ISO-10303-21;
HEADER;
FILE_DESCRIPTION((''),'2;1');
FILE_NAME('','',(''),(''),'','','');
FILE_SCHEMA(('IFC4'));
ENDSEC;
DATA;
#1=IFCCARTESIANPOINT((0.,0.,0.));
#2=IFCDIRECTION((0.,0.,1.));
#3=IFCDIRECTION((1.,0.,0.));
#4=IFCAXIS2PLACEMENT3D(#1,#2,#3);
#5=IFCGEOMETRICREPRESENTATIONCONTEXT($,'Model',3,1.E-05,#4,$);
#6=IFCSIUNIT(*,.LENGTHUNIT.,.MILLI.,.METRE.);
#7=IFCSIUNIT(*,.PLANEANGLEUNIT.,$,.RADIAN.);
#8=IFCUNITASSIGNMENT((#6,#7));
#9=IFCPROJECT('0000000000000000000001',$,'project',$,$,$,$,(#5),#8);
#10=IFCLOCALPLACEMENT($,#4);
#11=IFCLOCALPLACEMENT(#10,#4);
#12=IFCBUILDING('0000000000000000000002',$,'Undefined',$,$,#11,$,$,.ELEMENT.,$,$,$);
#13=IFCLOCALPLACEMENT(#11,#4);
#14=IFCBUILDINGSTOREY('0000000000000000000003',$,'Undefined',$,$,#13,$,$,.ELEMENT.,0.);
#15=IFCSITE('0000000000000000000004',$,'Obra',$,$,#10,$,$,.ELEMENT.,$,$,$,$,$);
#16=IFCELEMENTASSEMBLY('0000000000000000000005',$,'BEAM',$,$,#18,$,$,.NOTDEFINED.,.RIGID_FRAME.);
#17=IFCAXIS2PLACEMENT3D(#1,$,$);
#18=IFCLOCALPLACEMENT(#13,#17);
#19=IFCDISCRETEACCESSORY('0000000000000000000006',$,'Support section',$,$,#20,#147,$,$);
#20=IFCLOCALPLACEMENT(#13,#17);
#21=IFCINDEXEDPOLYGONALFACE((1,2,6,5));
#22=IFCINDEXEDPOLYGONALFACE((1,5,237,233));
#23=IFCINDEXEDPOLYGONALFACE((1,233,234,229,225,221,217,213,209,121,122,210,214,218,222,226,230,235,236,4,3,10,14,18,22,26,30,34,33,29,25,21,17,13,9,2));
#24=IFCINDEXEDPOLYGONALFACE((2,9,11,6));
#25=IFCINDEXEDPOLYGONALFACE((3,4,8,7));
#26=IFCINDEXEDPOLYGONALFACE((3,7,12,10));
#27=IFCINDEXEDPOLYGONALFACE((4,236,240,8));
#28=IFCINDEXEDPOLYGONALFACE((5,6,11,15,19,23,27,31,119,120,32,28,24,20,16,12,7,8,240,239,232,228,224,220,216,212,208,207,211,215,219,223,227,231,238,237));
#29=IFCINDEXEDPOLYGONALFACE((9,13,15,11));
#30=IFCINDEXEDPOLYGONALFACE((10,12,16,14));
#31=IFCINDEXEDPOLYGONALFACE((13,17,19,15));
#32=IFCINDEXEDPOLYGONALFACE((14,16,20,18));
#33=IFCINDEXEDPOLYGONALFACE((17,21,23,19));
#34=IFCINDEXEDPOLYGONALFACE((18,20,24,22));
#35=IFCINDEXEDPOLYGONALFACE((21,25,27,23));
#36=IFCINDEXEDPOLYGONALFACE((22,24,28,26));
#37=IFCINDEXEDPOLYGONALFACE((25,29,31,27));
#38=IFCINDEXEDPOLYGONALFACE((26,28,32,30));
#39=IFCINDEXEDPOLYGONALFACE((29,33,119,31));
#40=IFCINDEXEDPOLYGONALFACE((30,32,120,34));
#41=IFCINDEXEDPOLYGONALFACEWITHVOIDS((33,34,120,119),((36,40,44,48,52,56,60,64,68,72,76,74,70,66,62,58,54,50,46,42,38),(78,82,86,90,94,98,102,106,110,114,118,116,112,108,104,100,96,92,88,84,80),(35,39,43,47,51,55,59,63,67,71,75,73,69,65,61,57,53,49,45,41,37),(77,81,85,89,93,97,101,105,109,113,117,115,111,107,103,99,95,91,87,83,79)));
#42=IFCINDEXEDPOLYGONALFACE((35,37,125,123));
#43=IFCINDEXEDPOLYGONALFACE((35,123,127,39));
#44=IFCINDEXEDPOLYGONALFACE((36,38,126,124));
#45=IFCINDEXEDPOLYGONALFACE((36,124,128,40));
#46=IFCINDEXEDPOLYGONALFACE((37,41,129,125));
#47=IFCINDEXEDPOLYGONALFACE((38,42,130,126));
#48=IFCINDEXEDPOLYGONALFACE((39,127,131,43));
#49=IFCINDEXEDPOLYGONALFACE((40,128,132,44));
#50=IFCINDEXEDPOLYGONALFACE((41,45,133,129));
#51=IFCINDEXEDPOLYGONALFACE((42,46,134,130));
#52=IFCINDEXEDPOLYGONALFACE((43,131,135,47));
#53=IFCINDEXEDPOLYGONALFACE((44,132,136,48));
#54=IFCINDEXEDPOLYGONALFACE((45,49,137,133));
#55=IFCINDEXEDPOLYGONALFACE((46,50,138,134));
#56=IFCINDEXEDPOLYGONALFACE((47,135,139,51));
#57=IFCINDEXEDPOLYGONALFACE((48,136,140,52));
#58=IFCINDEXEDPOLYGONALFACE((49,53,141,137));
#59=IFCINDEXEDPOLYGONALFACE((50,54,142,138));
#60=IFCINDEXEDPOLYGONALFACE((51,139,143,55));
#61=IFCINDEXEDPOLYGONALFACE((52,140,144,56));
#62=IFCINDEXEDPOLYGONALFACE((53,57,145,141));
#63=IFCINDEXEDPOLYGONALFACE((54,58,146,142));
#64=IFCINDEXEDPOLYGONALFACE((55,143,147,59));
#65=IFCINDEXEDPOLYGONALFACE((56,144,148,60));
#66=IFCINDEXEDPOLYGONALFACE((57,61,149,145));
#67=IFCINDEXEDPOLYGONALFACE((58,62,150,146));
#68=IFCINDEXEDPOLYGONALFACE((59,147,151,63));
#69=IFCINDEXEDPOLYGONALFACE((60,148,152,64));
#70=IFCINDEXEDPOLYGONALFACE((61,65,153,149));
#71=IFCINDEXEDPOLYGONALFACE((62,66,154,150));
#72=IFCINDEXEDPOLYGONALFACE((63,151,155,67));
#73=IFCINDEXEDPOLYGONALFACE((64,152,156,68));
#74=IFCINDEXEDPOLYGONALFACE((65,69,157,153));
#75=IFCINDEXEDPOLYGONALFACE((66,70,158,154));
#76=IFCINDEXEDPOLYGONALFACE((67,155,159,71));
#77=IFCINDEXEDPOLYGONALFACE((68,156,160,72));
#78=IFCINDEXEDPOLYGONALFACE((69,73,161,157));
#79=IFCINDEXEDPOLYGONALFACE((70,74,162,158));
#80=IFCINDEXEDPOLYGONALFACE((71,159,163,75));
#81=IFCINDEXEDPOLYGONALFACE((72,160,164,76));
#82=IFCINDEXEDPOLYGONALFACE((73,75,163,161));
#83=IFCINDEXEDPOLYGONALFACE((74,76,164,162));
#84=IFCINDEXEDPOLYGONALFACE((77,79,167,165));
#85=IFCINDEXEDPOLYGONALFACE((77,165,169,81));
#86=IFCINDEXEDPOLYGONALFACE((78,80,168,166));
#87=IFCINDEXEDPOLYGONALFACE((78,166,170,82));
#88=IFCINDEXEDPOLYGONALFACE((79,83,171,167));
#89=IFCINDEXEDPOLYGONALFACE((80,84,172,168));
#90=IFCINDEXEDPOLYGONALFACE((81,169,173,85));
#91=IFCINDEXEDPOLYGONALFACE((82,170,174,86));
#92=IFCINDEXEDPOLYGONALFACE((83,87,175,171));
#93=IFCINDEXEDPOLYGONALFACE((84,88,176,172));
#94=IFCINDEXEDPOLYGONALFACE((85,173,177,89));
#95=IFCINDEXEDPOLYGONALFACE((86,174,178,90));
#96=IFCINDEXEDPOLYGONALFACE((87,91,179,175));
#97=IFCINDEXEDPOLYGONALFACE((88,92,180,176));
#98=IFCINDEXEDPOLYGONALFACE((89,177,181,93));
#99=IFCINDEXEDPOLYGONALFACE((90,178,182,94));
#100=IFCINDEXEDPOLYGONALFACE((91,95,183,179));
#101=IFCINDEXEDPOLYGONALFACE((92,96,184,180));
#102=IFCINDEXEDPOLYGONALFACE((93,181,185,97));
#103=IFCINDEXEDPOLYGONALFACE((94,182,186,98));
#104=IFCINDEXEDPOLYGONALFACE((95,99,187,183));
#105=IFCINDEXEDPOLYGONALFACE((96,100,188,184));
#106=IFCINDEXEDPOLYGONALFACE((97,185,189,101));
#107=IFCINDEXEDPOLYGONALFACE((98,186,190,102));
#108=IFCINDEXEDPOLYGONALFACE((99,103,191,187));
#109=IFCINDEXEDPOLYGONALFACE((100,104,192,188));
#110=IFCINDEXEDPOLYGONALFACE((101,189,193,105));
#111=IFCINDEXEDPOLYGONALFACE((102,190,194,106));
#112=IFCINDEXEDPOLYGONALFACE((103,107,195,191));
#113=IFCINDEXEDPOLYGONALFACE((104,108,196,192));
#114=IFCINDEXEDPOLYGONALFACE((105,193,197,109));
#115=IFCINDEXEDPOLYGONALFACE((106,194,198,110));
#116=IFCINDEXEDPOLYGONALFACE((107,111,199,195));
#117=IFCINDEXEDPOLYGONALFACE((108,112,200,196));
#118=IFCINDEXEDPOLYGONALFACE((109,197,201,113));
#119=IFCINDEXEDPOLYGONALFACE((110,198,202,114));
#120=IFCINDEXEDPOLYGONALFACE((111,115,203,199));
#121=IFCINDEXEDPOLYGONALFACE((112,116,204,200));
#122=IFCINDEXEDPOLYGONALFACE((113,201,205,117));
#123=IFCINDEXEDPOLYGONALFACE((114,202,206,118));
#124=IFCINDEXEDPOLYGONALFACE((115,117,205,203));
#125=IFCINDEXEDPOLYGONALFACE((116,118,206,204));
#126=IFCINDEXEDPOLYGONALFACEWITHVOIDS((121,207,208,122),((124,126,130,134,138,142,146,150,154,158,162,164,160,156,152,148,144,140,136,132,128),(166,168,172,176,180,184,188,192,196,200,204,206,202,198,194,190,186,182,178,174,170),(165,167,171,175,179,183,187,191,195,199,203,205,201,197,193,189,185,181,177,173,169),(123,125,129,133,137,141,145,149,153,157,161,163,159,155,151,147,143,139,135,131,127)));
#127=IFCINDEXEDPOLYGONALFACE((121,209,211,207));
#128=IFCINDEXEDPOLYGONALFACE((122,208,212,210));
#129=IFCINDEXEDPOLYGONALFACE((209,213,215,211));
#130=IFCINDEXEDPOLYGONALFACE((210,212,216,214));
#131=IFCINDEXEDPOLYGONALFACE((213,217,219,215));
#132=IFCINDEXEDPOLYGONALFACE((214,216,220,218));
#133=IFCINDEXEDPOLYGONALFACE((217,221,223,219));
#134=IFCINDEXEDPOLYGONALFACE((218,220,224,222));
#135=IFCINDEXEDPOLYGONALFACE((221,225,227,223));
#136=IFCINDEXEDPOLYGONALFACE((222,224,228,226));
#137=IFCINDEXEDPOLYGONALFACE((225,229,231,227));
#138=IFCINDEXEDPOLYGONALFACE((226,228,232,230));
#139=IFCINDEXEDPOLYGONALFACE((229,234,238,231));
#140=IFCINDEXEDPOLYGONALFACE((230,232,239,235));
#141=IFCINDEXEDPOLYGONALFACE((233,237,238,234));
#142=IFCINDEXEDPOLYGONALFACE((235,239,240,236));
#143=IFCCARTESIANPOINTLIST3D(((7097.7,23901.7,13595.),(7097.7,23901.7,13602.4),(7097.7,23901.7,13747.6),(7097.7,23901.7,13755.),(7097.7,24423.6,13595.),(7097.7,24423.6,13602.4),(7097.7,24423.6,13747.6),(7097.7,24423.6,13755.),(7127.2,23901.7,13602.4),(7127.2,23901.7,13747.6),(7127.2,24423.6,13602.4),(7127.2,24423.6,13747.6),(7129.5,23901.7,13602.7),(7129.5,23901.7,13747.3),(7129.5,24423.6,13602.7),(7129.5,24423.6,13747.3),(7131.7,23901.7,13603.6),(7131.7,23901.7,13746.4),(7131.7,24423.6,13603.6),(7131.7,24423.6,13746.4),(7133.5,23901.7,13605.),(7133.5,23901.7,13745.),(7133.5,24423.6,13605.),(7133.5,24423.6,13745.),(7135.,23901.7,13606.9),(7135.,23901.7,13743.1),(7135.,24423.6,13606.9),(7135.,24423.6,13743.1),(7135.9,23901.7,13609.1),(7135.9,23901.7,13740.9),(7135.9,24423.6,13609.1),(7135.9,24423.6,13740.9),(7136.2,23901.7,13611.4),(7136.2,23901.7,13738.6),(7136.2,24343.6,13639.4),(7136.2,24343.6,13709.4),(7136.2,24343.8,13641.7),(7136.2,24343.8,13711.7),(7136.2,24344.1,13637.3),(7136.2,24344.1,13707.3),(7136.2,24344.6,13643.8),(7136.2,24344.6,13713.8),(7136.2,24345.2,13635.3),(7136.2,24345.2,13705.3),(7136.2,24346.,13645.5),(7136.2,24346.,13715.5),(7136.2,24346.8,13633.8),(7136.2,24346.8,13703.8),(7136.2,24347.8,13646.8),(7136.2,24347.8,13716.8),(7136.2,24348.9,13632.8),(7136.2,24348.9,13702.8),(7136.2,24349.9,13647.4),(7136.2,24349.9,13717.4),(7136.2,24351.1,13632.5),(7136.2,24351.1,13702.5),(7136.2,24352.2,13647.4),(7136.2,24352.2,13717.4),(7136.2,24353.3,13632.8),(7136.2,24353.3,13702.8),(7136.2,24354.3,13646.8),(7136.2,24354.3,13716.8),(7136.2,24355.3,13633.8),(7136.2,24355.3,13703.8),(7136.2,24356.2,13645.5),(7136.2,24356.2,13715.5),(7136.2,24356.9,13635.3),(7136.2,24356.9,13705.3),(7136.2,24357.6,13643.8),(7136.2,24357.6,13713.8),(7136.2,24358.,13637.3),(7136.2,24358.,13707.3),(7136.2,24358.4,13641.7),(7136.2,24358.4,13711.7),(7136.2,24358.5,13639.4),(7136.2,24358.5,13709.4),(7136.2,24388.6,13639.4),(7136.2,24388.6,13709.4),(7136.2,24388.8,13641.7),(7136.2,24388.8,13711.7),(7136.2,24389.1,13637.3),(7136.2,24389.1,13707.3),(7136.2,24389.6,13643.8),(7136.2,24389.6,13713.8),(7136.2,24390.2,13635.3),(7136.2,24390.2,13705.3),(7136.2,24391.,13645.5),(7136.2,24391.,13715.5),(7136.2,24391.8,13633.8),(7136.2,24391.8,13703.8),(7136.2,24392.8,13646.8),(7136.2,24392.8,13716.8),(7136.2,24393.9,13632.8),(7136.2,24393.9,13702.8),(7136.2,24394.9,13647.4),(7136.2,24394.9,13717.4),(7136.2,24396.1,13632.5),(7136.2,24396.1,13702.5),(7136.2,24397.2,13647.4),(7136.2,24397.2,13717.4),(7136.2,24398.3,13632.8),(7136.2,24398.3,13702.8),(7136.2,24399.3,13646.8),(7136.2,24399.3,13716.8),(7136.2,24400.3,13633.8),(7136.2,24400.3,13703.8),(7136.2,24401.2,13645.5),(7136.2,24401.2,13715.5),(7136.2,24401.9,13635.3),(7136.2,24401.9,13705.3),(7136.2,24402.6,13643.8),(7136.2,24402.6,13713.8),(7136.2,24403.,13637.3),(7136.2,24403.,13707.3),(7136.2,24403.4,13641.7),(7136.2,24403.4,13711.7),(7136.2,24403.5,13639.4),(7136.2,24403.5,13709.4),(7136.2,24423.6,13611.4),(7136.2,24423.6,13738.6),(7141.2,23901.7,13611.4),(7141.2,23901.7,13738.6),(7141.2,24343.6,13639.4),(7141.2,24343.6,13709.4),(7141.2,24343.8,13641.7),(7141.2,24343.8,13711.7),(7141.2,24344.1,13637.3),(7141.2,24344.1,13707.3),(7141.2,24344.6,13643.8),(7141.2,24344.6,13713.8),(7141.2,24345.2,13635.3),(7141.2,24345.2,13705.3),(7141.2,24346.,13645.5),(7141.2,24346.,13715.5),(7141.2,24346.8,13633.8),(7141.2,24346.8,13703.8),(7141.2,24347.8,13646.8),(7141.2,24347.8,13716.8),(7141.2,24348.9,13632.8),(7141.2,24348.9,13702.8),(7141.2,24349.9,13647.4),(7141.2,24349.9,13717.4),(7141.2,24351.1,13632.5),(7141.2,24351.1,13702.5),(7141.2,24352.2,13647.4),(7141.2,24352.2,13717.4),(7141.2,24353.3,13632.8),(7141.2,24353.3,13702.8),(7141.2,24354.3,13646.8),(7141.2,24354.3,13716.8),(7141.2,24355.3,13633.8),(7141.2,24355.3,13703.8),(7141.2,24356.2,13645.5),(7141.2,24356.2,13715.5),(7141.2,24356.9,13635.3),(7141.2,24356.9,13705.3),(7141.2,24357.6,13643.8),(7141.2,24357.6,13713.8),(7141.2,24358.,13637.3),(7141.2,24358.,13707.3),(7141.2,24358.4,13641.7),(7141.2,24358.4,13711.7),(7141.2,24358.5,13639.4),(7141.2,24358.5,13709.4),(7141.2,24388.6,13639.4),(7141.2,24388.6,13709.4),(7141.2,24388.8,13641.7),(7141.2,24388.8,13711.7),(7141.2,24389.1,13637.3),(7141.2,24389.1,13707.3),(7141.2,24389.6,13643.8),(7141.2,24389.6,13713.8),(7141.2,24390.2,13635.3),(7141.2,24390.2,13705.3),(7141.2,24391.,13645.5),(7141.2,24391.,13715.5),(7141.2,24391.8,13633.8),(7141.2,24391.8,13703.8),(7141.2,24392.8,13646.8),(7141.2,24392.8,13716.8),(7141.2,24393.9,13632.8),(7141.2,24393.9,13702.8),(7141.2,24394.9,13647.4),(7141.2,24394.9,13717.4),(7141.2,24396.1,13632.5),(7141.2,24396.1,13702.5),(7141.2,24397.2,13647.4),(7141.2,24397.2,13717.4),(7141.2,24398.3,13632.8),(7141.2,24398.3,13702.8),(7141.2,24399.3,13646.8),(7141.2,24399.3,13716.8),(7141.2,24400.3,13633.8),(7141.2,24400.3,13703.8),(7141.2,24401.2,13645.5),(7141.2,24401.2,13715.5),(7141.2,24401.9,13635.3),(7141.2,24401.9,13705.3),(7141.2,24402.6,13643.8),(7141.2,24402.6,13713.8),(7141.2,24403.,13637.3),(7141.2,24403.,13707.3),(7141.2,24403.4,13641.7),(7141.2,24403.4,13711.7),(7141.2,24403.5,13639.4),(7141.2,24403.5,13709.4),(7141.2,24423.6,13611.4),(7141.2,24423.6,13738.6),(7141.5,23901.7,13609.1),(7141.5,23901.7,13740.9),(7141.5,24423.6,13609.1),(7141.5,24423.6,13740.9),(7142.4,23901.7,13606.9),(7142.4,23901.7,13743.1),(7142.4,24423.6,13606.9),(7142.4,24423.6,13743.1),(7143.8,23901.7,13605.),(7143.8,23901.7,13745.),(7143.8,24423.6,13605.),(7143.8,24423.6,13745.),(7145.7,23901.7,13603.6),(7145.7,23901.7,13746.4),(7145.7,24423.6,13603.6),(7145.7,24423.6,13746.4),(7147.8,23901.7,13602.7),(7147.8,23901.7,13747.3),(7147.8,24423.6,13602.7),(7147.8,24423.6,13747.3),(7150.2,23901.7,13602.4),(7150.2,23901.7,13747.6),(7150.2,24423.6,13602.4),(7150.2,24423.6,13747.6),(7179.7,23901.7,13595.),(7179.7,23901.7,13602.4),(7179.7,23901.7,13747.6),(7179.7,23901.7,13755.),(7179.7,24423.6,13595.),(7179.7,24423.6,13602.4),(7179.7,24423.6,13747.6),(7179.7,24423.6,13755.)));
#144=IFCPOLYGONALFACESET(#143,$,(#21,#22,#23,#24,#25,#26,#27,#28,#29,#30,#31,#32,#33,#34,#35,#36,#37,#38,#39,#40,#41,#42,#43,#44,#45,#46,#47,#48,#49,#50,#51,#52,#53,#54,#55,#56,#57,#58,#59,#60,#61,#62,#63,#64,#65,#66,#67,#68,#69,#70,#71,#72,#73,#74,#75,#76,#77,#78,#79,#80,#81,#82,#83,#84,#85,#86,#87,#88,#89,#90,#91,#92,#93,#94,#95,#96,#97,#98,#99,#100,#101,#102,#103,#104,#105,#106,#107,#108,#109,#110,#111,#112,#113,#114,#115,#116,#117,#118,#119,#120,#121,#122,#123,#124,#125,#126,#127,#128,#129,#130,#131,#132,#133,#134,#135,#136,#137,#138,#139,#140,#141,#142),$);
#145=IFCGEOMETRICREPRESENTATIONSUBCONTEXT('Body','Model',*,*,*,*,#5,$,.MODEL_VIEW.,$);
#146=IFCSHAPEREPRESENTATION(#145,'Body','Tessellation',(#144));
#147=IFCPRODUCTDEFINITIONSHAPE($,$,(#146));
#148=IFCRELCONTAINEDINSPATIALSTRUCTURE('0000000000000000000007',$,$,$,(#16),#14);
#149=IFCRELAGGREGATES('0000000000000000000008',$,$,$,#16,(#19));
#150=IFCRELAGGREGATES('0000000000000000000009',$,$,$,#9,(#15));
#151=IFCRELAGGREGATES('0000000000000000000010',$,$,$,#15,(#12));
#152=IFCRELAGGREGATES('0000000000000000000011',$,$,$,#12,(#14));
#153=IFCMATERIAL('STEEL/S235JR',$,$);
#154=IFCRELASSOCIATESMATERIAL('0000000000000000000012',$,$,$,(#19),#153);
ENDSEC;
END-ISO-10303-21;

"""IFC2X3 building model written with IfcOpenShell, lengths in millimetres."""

from ifc_helpers import new_model, si_unit, frame, origin_with_axes, origin_2d_with_axis, place, context, subcontext, project, spatial, circle, i_section, extrude, clip, halfspace, source, transform, mapped, material, element, aggregate, save


model = new_model("IFC2X3")

# Units and contexts
model_context = context("Model", 3, precision=1e-05, world=origin_with_axes())
body_context = subcontext(model_context, "Body", "Model", "MODEL_VIEW")
ifc_project = project(units=[si_unit("LENGTHUNIT", "METRE", prefix="MILLI"), si_unit("PLANEANGLEUNIT", "RADIAN")], contexts=[model_context])

# Site, building, storey
site_placement = place(None, origin_with_axes())
site = spatial("IfcSite", under=ifc_project, at=site_placement, Name="Obra", CompositionType="ELEMENT")
building_placement = place(site_placement, origin_with_axes())
building = spatial("IfcBuilding", under=site, at=building_placement, Name="Undefined", CompositionType="ELEMENT")
storey_placement = place(building_placement, origin_with_axes())
storey = spatial("IfcBuildingStorey", under=building, at=storey_placement, Name="Undefined", CompositionType="ELEMENT", Elevation=0.0)

# Element assembly
assembly_1_placement = place(storey_placement, origin_with_axes())
assembly_1 = element("IfcElementAssembly", 1, at=assembly_1_placement, inside=storey, Name="BEAM", AssemblyPlace="NOTDEFINED", PredefinedType="RIGID_FRAME")
ifc_material_1 = material(Name="STEEL/S235JR")

# Shared definitions
shared_shape_1 = source(origin_with_axes(), body_context, "Body", "SweptSolid", [
    extrude(circle(Radius=7.5, at=origin_2d_with_axis()), frame((0.0, -2.6, 0.0), z_axis=(0.0, 1.0, 0.0), x_axis=(1.0, 0.0, 0.0)), (0.0, 0.0, 1.0), 5.2),
])

# Discrete accessory, opening
discrete_accessory_1_placement = place(assembly_1_placement, frame((7138.7, 23991.9, 13675.0), z_axis=(0.0, 0.0, 1.0), x_axis=(0.0, 1.0, 0.0)))
discrete_accessory_1 = element("IfcDiscreteAccessory", 2, at=discrete_accessory_1_placement, material=ifc_material_1, Name="Support section", context=body_context, shape_type="Clipping", body=[
    clip(clip(extrude(i_section(OverallWidth=82.0, OverallDepth=160.0, WebThickness=5.0, FlangeThickness=7.4, FilletRadius=9.0, at=origin_2d_with_axis()), frame((431.7, 0.0, 0.0), z_axis=(-1.0, 0.0, 0.0), x_axis=(0.0, -1.0, 0.0)), (0.0, 0.0, 1.0), 521.8), halfspace(frame((431.7, 0.0, -180.0), z_axis=(-1.0, 0.0, 0.0), x_axis=(0.0, 1.0, 0.0)), True)), halfspace(frame((-90.1, 0.0, 580.0), z_axis=(-1.0, -0.000446, 0.0), x_axis=(0.000446, -1.0, 0.0)), False)),
])
opening_1_placement = place(assembly_1_placement, frame((7138.7, 24373.6, 13710.0), z_axis=(0.0, -1.0, 0.0), x_axis=(0.0, 0.0, -1.0)))
element("IfcOpeningElement", 3, at=opening_1_placement, cuts=discrete_accessory_1, ObjectType="Opening", context=body_context, shape_type="MappedRepresentation", body=[
    mapped(shared_shape_1, transform((0.0, 0.0, -22.5))),
    mapped(shared_shape_1, transform((70.0, 0.0, -22.5))),
    mapped(shared_shape_1, transform((0.0, 0.0, 22.5))),
    mapped(shared_shape_1, transform((70.0, 0.0, 22.5))),
])
aggregate(assembly_1, [discrete_accessory_1])

save(model, "model.ifc")
